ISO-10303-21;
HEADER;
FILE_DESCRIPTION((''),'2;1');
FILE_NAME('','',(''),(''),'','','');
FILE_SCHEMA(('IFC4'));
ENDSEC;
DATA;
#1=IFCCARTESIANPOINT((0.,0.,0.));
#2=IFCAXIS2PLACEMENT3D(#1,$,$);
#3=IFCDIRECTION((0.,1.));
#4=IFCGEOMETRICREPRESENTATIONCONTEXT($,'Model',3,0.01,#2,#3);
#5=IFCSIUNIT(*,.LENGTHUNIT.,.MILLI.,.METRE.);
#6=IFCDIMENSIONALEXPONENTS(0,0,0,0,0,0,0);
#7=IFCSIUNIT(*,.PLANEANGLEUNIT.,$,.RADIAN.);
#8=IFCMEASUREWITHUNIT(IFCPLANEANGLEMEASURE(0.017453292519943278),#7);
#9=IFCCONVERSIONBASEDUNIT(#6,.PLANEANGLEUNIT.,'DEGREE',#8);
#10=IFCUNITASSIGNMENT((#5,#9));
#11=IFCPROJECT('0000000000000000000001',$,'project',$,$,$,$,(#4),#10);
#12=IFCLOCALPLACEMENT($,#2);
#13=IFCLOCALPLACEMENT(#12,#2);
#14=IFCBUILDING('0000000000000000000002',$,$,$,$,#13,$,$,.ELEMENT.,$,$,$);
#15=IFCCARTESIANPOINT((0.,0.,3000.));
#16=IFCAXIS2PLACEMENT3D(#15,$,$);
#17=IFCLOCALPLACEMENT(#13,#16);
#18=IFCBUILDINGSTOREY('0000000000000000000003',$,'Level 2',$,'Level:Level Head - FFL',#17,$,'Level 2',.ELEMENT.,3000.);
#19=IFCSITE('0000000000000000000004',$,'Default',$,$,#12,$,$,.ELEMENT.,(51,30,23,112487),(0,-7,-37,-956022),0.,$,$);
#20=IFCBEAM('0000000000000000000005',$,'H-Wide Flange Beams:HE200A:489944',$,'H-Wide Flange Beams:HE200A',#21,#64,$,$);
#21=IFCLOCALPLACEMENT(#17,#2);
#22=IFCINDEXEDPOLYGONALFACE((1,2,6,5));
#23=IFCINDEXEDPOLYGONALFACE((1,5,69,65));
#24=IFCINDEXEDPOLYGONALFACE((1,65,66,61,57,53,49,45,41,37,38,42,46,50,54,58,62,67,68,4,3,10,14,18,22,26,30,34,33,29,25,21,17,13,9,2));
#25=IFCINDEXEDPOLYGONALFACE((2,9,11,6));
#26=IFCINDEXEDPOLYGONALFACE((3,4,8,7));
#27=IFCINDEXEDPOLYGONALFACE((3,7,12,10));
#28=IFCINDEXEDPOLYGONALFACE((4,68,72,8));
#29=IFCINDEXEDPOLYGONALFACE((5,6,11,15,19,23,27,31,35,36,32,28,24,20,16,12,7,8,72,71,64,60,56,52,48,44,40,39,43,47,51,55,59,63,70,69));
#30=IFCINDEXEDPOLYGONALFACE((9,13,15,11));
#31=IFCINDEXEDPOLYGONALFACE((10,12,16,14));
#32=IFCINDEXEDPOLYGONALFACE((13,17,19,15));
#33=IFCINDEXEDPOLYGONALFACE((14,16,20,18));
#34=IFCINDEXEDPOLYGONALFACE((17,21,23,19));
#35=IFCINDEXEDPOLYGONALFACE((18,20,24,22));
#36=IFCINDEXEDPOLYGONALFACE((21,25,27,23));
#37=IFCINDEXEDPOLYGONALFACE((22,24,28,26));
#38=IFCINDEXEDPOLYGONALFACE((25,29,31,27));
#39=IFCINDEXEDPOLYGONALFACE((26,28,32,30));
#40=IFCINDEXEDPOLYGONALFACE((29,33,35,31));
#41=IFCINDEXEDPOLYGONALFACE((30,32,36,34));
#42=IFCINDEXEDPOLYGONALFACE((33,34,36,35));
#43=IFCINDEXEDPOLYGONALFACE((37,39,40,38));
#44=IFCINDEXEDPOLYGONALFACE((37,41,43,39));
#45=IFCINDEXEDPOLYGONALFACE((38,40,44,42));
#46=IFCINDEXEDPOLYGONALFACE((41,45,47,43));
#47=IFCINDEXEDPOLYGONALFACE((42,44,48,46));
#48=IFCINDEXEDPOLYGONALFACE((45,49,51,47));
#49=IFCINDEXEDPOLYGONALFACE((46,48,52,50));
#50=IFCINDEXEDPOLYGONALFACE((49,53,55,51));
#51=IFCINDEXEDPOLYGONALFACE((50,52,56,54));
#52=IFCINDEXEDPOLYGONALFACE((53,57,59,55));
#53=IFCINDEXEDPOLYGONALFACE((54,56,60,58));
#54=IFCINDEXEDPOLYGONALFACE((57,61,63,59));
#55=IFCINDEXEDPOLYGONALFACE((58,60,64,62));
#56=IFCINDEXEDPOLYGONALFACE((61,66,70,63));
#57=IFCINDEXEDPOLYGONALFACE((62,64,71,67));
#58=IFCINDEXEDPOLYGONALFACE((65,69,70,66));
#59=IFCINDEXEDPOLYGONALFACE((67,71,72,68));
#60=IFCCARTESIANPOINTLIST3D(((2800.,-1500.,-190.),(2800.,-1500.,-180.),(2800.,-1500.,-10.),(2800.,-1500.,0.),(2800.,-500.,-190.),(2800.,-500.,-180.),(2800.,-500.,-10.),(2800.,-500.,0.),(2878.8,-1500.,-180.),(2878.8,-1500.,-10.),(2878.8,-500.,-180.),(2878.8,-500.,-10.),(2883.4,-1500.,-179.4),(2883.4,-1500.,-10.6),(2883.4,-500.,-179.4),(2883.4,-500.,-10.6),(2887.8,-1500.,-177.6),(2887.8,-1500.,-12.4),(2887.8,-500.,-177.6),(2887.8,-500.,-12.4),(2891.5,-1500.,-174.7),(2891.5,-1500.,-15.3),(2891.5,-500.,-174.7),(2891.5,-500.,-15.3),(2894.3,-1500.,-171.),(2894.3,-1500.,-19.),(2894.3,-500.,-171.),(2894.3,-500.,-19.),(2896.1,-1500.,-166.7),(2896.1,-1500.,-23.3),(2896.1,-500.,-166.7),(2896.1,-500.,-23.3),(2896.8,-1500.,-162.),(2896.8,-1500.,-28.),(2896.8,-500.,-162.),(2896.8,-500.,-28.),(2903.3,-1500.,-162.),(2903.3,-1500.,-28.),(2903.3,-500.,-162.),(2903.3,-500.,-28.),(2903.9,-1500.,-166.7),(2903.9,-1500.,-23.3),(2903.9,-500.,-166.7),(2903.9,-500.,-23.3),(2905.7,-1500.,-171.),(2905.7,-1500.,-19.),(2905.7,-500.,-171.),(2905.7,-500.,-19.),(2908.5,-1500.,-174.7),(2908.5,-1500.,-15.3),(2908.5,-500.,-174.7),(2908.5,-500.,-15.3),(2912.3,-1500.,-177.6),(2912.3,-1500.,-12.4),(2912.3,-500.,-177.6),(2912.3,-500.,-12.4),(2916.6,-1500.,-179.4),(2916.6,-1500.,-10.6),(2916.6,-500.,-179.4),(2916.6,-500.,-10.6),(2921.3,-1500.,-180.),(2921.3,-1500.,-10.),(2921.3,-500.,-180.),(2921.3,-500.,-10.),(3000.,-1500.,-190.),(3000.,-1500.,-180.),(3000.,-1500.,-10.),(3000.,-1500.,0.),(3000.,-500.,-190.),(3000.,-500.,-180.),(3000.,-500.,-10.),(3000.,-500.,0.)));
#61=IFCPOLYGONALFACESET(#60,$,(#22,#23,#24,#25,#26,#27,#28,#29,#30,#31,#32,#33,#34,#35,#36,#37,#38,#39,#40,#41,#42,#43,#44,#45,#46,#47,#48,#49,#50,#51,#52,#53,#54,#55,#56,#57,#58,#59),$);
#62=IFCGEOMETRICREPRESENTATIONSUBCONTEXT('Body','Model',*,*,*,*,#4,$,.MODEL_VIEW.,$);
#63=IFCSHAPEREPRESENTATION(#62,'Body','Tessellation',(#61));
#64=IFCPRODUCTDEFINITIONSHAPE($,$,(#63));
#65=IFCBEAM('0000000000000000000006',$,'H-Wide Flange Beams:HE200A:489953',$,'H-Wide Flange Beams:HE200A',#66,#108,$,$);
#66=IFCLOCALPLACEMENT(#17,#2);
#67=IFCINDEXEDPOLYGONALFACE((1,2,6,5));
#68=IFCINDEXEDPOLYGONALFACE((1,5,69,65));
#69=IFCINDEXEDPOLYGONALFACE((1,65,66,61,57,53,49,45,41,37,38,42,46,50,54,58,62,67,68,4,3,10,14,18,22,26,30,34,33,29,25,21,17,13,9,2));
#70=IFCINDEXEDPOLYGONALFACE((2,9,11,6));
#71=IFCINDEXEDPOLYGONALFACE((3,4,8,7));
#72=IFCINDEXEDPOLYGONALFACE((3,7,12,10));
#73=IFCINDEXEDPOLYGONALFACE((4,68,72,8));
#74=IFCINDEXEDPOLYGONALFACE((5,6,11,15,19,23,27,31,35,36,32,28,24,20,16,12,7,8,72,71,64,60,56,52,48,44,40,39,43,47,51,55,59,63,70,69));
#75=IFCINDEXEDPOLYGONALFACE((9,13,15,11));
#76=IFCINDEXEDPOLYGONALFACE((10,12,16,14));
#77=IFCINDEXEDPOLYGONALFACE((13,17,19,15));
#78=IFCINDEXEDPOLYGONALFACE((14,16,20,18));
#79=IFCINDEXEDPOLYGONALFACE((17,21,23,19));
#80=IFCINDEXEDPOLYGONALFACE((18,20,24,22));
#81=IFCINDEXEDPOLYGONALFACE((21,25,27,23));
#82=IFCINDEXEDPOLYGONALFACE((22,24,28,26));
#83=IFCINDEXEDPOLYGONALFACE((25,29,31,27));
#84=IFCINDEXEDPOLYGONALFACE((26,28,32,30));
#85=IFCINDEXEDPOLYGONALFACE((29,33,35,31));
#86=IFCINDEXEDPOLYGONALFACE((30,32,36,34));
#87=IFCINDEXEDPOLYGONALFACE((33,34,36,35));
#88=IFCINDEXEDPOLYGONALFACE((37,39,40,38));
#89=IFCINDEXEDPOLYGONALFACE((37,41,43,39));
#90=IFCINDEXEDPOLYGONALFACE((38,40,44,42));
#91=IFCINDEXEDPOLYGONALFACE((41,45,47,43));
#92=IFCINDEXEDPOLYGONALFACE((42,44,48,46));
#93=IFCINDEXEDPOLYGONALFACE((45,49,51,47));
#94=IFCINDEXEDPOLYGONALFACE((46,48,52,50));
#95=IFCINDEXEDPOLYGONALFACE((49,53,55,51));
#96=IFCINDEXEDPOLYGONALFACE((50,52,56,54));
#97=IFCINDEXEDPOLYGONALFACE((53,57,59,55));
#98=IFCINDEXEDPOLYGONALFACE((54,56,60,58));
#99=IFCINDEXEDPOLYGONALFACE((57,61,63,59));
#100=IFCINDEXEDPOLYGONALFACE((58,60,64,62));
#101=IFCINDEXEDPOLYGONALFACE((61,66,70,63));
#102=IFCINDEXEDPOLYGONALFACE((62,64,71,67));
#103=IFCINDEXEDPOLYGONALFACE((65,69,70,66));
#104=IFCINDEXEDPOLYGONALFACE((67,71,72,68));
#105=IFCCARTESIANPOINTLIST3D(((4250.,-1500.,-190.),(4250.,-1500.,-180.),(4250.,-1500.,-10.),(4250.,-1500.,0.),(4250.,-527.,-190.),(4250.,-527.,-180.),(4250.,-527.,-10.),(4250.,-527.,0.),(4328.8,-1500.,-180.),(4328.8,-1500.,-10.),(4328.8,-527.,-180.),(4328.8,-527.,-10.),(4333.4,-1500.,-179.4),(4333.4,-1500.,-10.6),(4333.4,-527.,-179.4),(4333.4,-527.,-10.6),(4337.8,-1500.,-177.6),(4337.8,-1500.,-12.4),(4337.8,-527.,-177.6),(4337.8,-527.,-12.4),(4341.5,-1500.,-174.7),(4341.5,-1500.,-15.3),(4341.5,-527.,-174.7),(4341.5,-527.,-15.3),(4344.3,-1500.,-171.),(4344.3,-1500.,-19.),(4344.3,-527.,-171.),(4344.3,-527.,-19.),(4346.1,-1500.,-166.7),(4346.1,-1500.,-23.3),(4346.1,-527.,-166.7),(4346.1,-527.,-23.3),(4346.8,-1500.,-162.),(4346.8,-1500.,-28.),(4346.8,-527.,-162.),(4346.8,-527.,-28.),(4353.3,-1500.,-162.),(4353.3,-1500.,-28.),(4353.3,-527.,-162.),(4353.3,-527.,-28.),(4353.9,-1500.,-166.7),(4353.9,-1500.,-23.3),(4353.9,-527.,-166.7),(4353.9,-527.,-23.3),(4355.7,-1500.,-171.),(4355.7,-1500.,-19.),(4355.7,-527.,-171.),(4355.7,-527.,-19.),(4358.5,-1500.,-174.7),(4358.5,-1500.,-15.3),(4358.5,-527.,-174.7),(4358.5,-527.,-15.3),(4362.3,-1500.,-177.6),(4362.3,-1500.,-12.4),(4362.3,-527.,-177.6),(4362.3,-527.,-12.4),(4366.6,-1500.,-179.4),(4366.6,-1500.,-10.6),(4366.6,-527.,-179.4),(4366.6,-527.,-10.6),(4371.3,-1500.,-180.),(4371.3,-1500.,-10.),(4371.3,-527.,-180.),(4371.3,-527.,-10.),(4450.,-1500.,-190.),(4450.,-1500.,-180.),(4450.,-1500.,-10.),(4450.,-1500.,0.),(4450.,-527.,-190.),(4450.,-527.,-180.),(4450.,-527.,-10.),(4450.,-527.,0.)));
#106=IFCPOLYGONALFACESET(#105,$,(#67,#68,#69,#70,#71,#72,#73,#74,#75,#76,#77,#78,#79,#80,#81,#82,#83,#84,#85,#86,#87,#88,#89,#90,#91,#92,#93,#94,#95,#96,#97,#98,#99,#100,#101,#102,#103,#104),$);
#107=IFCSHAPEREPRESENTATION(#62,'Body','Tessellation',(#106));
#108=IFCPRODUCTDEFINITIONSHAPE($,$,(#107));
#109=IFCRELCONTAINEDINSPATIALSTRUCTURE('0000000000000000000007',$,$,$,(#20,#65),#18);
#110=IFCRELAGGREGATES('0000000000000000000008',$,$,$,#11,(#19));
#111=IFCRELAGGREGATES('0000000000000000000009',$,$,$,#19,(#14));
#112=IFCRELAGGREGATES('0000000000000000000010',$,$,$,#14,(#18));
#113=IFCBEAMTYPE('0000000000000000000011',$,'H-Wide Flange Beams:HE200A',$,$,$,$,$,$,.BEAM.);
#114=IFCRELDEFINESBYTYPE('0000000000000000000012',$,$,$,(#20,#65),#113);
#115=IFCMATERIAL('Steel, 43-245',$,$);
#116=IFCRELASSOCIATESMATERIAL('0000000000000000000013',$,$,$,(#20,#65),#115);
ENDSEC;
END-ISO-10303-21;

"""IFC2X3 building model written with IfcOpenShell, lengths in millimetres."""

from ifc_helpers import new_model, entity, si_unit, converted_unit, direction, frame, frame_2d, origin, place, context, subcontext, project, spatial, i_section, extrude, material, type_object, element, save


model = new_model("IFC2X3")

# Units and contexts
model_context = context("Model", 3, precision=0.01, world=origin(), true_north=direction((0.0, 1.0)))
body_context = subcontext(model_context, "Body", "Model", "MODEL_VIEW")
ifc_project = project(units=[si_unit("LENGTHUNIT", "METRE", prefix="MILLI"), converted_unit("PLANEANGLEUNIT", "DEGREE", entity("IfcPlaneAngleMeasure", 0.017453292519943278), si_unit("PLANEANGLEUNIT", "RADIAN"), dimensions=[0, 0, 0, 0, 0, 0, 0])], contexts=[model_context])

# Site, building, storey
site_placement = place(None, origin())
site = spatial("IfcSite", under=ifc_project, at=site_placement, Name="Default", CompositionType="ELEMENT", RefLatitude=(51, 30, 23, 112487), RefLongitude=(0, -7, -37, -956022), RefElevation=0.0)
building_placement = place(site_placement, origin())
building = spatial("IfcBuilding", under=site, at=building_placement, CompositionType="ELEMENT")
storey_placement = place(building_placement, frame((0.0, 0.0, 3000.0)))
storey = spatial("IfcBuildingStorey", under=building, at=storey_placement, Name="Level 2", ObjectType="Level:Level Head - FFL", LongName="Level 2", CompositionType="ELEMENT", Elevation=3000.0)

# Shared definitions
ifc_material = material(Name="Steel, 43-245")

# Beams
beam_type_1 = type_object("IfcBeamType", Name="H-Wide Flange Beams:HE200A", PredefinedType="BEAM")
beam_1_placement = place(storey_placement, frame((2900.0, -1500.0, 0.0), z_axis=(0.0, 0.0, 1.0), x_axis=(0.0, 1.0, 0.0)))
element("IfcBeam", 1, at=beam_1_placement, inside=storey, type_object=beam_type_1, material=ifc_material, Name="H-Wide Flange Beams:HE200A:489944", ObjectType="H-Wide Flange Beams:HE200A", context=body_context, shape_type="SweptSolid", body=[
    extrude(i_section(OverallWidth=200.0, OverallDepth=190.0, WebThickness=6.5, FlangeThickness=10.0, FilletRadius=18.0, at=frame_2d((0.0, 0.0), x_axis=(0.0, 1.0))), frame((0.0, 0.0, -95.0), z_axis=(1.0, 0.0, 0.0), x_axis=(0.0, 0.0, -1.0)), (0.0, 0.0, 1.0), 1000.0),
])
beam_2_placement = place(storey_placement, frame((4350.0, -1500.0, 0.0), z_axis=(0.0, 0.0, 1.0), x_axis=(0.0, 1.0, 0.0)))
element("IfcBeam", 2, at=beam_2_placement, inside=storey, type_object=beam_type_1, material=ifc_material, Name="H-Wide Flange Beams:HE200A:489953", ObjectType="H-Wide Flange Beams:HE200A", context=body_context, shape_type="SweptSolid", body=[
    extrude(i_section(OverallWidth=200.0, OverallDepth=190.0, WebThickness=6.5, FlangeThickness=10.0, FilletRadius=18.0, at=frame_2d((0.0, 0.0), x_axis=(0.0, 1.0))), frame((0.0, 0.0, -95.0), z_axis=(1.0, 0.0, 0.0), x_axis=(0.0, 0.0, -1.0)), (0.0, 0.0, 1.0), 973.0),
])

save(model, "model.ifc")
